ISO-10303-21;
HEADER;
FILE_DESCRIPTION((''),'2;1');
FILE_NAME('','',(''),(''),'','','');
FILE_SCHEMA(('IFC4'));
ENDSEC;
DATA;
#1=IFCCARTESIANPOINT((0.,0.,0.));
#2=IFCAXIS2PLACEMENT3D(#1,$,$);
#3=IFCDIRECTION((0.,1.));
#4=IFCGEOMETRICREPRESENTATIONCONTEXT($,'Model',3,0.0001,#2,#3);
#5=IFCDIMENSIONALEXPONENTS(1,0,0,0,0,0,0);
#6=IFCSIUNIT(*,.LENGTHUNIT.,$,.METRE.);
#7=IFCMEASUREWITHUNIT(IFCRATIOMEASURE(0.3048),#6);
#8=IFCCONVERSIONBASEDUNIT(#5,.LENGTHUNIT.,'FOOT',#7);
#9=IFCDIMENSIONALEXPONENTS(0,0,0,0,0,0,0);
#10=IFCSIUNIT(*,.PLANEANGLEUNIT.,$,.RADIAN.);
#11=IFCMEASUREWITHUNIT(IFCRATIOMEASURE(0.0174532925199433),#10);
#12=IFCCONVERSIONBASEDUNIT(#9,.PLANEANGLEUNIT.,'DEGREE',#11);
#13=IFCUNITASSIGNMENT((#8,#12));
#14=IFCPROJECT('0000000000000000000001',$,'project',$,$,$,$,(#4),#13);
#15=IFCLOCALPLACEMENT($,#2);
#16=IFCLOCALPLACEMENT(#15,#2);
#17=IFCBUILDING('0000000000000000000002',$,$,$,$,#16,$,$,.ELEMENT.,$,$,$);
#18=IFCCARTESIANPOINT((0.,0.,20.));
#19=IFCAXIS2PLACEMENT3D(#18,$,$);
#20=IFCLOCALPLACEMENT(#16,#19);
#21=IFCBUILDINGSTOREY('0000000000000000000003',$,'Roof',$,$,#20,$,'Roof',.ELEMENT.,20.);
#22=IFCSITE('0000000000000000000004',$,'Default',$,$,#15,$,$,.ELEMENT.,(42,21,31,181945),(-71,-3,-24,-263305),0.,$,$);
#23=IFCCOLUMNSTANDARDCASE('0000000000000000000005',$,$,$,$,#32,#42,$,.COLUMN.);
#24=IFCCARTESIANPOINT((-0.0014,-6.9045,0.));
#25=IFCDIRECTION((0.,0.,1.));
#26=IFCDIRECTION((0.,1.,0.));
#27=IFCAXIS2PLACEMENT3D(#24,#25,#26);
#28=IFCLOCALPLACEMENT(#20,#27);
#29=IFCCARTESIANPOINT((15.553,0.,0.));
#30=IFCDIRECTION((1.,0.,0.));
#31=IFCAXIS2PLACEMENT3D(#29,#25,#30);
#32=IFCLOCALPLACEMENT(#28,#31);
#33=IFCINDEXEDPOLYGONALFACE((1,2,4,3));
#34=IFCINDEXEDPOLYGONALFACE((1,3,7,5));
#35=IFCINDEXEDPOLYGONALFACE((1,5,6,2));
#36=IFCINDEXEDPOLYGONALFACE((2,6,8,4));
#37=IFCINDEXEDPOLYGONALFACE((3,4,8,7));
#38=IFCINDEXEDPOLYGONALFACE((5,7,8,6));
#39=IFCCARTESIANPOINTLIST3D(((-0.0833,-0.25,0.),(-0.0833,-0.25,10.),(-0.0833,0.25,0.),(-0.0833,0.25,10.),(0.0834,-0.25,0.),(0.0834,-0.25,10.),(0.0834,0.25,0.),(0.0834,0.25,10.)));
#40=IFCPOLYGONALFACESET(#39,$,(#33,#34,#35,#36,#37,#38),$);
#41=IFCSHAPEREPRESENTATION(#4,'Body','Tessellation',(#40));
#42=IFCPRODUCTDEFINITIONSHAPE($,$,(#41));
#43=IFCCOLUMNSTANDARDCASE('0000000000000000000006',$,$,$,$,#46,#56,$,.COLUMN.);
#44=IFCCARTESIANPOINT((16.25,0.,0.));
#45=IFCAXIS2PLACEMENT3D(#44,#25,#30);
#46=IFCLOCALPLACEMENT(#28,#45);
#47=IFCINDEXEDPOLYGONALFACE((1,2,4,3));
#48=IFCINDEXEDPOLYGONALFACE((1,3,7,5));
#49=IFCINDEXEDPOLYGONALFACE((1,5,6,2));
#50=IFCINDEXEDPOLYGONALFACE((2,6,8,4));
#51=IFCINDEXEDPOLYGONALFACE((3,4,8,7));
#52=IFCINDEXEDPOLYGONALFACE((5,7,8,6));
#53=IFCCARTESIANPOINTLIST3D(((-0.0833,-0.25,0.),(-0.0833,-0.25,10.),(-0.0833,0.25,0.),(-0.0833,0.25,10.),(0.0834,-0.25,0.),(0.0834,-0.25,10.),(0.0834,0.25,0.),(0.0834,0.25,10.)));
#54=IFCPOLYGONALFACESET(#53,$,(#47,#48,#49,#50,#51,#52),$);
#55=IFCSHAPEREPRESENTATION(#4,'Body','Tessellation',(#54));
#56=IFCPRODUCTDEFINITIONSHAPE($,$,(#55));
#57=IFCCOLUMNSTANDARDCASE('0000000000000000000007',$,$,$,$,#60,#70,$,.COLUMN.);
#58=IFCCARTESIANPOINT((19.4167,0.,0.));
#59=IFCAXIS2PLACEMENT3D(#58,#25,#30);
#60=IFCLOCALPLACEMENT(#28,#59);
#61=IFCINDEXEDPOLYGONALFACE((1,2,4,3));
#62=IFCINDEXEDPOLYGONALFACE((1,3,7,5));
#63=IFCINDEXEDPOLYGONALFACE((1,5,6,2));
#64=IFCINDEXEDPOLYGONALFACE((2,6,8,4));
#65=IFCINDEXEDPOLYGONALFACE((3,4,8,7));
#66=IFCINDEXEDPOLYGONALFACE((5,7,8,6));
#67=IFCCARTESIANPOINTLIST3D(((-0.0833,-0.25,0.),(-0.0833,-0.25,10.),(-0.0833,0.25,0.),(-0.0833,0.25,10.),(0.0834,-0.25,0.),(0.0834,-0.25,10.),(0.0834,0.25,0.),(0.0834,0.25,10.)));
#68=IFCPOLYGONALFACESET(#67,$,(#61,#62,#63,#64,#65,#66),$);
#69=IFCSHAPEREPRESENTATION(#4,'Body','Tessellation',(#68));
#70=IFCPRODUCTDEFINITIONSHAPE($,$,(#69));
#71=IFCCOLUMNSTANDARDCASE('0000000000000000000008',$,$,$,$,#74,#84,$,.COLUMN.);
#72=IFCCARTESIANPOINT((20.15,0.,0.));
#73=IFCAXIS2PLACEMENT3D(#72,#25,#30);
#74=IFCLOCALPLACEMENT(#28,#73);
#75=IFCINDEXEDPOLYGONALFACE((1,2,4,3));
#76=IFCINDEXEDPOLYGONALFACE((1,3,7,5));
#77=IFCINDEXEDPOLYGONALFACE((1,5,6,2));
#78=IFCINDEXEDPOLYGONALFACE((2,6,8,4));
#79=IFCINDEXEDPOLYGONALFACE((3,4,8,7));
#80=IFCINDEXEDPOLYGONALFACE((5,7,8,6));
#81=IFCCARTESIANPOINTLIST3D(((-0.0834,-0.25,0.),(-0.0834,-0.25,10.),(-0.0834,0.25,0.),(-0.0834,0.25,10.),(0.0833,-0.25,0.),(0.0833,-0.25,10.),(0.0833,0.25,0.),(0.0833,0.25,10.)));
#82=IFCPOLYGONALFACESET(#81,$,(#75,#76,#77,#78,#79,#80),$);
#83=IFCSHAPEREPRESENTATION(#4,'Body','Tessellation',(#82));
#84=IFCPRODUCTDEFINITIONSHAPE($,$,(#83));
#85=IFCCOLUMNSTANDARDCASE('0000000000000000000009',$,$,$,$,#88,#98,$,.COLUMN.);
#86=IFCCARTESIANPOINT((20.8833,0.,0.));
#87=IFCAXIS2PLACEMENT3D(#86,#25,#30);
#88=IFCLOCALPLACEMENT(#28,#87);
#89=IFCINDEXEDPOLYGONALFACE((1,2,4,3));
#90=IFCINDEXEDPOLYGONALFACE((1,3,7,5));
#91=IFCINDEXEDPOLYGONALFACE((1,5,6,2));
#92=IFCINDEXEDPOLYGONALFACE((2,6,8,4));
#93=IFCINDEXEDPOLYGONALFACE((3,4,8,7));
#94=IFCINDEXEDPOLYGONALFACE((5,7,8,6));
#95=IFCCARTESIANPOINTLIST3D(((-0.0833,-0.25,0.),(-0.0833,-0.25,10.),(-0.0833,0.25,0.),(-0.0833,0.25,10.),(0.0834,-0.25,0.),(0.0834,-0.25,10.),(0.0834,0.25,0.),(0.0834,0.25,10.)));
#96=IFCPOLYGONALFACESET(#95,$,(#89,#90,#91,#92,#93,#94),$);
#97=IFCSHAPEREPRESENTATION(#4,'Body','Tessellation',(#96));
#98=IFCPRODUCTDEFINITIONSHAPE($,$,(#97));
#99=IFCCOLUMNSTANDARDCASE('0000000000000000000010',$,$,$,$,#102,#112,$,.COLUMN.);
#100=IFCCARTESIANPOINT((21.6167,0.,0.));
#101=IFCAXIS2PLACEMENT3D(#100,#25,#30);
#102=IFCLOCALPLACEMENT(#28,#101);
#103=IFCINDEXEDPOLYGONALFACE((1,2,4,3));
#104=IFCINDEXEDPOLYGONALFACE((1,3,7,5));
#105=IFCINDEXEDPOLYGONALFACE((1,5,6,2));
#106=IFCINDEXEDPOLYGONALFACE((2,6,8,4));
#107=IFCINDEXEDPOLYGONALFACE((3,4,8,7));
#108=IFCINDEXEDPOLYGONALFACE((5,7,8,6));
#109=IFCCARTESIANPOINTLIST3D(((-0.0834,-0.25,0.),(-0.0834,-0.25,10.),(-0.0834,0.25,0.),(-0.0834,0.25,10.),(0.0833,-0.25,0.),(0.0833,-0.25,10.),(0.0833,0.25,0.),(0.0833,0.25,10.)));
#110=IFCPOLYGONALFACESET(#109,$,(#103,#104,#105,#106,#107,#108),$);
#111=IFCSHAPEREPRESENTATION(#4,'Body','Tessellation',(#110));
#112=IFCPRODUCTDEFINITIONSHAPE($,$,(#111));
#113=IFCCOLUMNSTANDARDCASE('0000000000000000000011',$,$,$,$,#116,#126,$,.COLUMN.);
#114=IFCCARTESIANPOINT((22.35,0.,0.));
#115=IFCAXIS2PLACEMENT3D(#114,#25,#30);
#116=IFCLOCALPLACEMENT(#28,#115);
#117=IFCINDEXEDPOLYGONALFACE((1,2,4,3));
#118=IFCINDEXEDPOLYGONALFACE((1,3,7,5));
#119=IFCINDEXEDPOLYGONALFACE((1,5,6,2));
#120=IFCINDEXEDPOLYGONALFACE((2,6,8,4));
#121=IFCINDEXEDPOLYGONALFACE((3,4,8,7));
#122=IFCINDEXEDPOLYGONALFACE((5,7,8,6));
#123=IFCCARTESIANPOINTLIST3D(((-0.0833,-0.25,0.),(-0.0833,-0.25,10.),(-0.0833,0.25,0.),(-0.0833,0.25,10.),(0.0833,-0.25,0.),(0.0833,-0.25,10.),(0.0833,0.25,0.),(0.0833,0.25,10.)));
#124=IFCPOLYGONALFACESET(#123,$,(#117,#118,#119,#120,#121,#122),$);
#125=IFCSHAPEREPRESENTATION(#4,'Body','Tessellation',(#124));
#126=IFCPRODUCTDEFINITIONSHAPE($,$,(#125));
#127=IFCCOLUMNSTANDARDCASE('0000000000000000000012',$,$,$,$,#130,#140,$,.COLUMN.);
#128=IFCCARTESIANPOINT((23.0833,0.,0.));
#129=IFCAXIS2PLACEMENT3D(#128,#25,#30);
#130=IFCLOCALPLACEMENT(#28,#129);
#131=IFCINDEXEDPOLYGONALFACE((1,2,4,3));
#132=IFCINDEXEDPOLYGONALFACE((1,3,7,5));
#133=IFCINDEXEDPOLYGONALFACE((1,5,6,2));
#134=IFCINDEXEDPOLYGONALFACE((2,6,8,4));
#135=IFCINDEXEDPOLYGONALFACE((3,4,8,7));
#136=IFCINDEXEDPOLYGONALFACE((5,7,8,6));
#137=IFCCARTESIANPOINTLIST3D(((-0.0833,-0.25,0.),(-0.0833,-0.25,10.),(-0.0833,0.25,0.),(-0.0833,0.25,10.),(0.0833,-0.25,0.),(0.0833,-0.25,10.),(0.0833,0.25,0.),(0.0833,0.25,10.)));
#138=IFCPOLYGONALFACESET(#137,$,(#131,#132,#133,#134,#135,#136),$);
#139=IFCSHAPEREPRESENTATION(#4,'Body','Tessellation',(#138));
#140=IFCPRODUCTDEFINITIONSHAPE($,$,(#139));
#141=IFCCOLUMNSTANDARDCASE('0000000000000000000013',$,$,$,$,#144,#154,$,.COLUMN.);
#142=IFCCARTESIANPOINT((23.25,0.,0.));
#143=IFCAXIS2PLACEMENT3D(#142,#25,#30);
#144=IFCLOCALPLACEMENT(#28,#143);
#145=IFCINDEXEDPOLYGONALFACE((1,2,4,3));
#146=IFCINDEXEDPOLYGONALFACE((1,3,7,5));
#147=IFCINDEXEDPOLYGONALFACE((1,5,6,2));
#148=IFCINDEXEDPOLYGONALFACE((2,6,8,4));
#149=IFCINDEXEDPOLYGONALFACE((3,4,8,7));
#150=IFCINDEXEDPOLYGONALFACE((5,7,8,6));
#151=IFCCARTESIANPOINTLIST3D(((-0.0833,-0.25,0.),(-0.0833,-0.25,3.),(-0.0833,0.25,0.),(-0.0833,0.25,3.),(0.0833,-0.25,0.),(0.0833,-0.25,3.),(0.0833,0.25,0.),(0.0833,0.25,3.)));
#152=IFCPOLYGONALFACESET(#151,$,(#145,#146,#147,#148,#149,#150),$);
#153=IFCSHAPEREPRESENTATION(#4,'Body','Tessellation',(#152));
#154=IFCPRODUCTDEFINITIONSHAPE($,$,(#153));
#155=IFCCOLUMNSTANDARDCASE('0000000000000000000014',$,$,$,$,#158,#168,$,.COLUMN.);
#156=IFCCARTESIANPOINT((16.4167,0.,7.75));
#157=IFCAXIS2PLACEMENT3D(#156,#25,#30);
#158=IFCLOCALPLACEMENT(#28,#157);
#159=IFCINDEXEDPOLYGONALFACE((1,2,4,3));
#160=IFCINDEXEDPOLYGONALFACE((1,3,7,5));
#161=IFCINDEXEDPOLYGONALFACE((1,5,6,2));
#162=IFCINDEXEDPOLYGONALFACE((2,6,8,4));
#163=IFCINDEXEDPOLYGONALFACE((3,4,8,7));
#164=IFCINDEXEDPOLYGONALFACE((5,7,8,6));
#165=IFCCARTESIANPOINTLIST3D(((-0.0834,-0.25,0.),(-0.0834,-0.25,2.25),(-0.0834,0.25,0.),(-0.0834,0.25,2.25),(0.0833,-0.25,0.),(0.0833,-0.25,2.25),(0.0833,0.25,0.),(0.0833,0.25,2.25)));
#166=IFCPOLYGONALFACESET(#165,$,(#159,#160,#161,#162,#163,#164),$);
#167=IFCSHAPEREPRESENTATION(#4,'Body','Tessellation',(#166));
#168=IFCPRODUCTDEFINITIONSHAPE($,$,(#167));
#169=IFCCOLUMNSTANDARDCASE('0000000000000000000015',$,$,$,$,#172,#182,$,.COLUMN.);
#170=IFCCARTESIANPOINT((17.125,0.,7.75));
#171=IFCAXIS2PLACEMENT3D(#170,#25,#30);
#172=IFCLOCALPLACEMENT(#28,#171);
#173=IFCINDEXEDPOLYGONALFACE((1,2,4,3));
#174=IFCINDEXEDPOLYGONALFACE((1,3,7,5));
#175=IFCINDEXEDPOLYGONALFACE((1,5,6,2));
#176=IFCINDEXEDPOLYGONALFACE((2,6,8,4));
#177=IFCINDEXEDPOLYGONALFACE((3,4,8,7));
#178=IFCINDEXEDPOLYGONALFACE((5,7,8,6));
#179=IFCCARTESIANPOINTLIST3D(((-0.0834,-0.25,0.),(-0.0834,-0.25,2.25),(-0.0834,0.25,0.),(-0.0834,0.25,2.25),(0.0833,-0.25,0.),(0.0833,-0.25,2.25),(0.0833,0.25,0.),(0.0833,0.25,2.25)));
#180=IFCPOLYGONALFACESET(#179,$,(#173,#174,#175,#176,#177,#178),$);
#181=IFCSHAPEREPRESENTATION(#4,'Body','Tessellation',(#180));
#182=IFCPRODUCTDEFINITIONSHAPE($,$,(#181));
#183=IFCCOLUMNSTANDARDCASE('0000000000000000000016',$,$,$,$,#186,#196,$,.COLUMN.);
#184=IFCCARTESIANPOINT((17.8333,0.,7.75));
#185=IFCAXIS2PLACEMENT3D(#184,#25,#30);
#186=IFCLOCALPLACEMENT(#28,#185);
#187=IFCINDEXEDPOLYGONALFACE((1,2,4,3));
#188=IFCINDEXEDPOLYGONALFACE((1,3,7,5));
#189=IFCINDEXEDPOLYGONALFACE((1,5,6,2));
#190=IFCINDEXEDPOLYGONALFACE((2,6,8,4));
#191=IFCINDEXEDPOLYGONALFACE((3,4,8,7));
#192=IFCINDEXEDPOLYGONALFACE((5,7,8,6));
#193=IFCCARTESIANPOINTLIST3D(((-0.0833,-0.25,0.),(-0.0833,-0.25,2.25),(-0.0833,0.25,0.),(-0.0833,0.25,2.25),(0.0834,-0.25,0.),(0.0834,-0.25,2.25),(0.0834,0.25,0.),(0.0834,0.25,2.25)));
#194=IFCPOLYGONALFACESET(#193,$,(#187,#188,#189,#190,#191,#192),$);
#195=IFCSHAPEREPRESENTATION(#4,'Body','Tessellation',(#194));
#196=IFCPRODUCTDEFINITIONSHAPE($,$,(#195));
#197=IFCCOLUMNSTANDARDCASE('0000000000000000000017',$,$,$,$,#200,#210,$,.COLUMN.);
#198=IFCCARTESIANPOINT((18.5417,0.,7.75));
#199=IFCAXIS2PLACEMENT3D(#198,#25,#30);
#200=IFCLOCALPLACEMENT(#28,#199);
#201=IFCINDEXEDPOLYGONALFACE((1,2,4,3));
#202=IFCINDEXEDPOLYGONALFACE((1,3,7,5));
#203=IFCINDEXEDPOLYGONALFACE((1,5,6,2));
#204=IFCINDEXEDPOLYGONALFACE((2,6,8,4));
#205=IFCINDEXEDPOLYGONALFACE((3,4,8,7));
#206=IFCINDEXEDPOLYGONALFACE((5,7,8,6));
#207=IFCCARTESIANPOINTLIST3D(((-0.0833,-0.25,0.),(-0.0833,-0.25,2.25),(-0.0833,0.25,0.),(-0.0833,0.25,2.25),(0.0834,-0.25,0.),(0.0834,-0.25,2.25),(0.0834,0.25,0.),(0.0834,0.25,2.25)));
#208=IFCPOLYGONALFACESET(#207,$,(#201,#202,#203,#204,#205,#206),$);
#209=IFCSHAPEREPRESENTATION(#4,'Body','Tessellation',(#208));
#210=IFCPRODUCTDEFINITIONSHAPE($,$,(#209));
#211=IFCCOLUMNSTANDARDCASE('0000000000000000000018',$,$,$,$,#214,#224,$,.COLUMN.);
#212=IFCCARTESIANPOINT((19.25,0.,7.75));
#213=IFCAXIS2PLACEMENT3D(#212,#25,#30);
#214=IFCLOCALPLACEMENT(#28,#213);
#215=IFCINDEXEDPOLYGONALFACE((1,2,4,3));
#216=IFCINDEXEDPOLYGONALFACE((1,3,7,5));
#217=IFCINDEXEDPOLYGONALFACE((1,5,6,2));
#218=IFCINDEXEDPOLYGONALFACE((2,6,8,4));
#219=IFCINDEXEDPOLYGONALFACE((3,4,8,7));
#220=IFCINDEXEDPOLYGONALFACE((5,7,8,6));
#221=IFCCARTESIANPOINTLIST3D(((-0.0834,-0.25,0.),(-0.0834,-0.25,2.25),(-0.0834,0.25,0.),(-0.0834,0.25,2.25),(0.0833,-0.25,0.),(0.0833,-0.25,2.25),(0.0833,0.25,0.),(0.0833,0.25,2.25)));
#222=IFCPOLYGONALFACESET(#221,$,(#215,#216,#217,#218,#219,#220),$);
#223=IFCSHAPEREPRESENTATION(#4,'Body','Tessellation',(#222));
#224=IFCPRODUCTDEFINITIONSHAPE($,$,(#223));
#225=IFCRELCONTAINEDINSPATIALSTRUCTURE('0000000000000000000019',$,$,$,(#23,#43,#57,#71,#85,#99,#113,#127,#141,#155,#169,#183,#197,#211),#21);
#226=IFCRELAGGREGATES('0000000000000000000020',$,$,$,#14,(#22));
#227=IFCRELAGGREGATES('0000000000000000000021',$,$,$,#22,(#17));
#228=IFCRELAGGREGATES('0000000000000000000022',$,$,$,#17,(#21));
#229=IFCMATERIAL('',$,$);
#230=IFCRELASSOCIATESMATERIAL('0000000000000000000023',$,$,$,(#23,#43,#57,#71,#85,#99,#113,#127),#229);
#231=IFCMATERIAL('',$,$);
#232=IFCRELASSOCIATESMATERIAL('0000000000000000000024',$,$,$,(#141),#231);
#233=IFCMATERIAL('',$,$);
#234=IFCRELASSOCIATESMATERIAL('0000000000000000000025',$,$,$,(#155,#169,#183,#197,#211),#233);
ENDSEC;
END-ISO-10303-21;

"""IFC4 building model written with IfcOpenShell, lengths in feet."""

from ifc_helpers import new_model, entity, si_unit, converted_unit, direction, frame, origin, place, context, project, spatial, rectangle, extrude, material, element, save


model = new_model("IFC4")

# Units and contexts
model_context = context("Model", 3, precision=0.0001, world=origin(), true_north=direction((0.0, 1.0)))
ifc_project = project(units=[converted_unit("LENGTHUNIT", "FOOT", entity("IfcRatioMeasure", 0.3048), si_unit("LENGTHUNIT", "METRE"), dimensions=[1, 0, 0, 0, 0, 0, 0]), converted_unit("PLANEANGLEUNIT", "DEGREE", entity("IfcRatioMeasure", 0.0174532925199433), si_unit("PLANEANGLEUNIT", "RADIAN"), dimensions=[0, 0, 0, 0, 0, 0, 0])], contexts=[model_context])

# Site, building, storey
site_placement = place(None, origin())
site = spatial("IfcSite", under=ifc_project, at=site_placement, Name="Default", CompositionType="ELEMENT", RefLatitude=(42, 21, 31, 181945), RefLongitude=(-71, -3, -24, -263305), RefElevation=0.0)
building_placement = place(site_placement, origin())
building = spatial("IfcBuilding", under=site, at=building_placement, CompositionType="ELEMENT")
storey_placement = place(building_placement, frame((0.0, 0.0, 20.0)))
storey = spatial("IfcBuildingStorey", under=building, at=storey_placement, Name="Roof", LongName="Roof", CompositionType="ELEMENT", Elevation=20.0)

# Columns
ifc_material_1 = material(Name="")
placement = place(storey_placement, frame((-0.0014, -6.9045, 0.0), z_axis=(0.0, 0.0, 1.0), x_axis=(0.0, 1.0, 0.0)))
for number, where, z_axis, x_axis in (
    (1, (15.553, 0.0, 0.0), (0.0, 0.0, 1.0), (1.0, 0.0, 0.0)),
    (2, (16.25, 0.0, 0.0), (0.0, 0.0, 1.0), (1.0, 0.0, 0.0)),
    (3, (19.4167, 0.0, 0.0), (0.0, 0.0, 1.0), (1.0, 0.0, 0.0)),
    (4, (20.15, 0.0, 0.0), (0.0, 0.0, 1.0), (1.0, 0.0, 0.0)),
    (5, (20.8833, 0.0, 0.0), (0.0, 0.0, 1.0), (1.0, 0.0, 0.0)),
    (6, (21.6167, 0.0, 0.0), (0.0, 0.0, 1.0), (1.0, 0.0, 0.0)),
    (7, (22.35, 0.0, 0.0), (0.0, 0.0, 1.0), (1.0, 0.0, 0.0)),
    (8, (23.0833, 0.0, 0.0), (0.0, 0.0, 1.0), (1.0, 0.0, 0.0)),
):
    element("IfcColumnStandardCase", number, at=place(placement, frame(where, z_axis=z_axis, x_axis=x_axis)), inside=storey, material=ifc_material_1, PredefinedType="COLUMN", context=model_context, shape_type="SweptSolid", body=[
        extrude(rectangle(XDim=0.1667, YDim=0.5), origin(), (0.0, 0.0, 1.0), 10.0),
    ])
ifc_material_2 = material(Name="")
for number, where, z_axis, x_axis in (
    (9, (23.25, 0.0, 0.0), (0.0, 0.0, 1.0), (1.0, 0.0, 0.0)),
):
    element("IfcColumnStandardCase", number, at=place(placement, frame(where, z_axis=z_axis, x_axis=x_axis)), inside=storey, material=ifc_material_2, PredefinedType="COLUMN", context=model_context, shape_type="SweptSolid", body=[
        extrude(rectangle(XDim=0.1667, YDim=0.5), origin(), (0.0, 0.0, 1.0), 3.0),
    ])
ifc_material_3 = material(Name="")
for number, where, z_axis, x_axis in (
    (10, (16.4167, 0.0, 7.75), (0.0, 0.0, 1.0), (1.0, 0.0, 0.0)),
    (11, (17.125, 0.0, 7.75), (0.0, 0.0, 1.0), (1.0, 0.0, 0.0)),
    (12, (17.8333, 0.0, 7.75), (0.0, 0.0, 1.0), (1.0, 0.0, 0.0)),
    (13, (18.5417, 0.0, 7.75), (0.0, 0.0, 1.0), (1.0, 0.0, 0.0)),
    (14, (19.25, 0.0, 7.75), (0.0, 0.0, 1.0), (1.0, 0.0, 0.0)),
):
    element("IfcColumnStandardCase", number, at=place(placement, frame(where, z_axis=z_axis, x_axis=x_axis)), inside=storey, material=ifc_material_3, PredefinedType="COLUMN", context=model_context, shape_type="SweptSolid", body=[
        extrude(rectangle(XDim=0.1667, YDim=0.5), origin(), (0.0, 0.0, 1.0), 2.25),
    ])

save(model, "model.ifc")
